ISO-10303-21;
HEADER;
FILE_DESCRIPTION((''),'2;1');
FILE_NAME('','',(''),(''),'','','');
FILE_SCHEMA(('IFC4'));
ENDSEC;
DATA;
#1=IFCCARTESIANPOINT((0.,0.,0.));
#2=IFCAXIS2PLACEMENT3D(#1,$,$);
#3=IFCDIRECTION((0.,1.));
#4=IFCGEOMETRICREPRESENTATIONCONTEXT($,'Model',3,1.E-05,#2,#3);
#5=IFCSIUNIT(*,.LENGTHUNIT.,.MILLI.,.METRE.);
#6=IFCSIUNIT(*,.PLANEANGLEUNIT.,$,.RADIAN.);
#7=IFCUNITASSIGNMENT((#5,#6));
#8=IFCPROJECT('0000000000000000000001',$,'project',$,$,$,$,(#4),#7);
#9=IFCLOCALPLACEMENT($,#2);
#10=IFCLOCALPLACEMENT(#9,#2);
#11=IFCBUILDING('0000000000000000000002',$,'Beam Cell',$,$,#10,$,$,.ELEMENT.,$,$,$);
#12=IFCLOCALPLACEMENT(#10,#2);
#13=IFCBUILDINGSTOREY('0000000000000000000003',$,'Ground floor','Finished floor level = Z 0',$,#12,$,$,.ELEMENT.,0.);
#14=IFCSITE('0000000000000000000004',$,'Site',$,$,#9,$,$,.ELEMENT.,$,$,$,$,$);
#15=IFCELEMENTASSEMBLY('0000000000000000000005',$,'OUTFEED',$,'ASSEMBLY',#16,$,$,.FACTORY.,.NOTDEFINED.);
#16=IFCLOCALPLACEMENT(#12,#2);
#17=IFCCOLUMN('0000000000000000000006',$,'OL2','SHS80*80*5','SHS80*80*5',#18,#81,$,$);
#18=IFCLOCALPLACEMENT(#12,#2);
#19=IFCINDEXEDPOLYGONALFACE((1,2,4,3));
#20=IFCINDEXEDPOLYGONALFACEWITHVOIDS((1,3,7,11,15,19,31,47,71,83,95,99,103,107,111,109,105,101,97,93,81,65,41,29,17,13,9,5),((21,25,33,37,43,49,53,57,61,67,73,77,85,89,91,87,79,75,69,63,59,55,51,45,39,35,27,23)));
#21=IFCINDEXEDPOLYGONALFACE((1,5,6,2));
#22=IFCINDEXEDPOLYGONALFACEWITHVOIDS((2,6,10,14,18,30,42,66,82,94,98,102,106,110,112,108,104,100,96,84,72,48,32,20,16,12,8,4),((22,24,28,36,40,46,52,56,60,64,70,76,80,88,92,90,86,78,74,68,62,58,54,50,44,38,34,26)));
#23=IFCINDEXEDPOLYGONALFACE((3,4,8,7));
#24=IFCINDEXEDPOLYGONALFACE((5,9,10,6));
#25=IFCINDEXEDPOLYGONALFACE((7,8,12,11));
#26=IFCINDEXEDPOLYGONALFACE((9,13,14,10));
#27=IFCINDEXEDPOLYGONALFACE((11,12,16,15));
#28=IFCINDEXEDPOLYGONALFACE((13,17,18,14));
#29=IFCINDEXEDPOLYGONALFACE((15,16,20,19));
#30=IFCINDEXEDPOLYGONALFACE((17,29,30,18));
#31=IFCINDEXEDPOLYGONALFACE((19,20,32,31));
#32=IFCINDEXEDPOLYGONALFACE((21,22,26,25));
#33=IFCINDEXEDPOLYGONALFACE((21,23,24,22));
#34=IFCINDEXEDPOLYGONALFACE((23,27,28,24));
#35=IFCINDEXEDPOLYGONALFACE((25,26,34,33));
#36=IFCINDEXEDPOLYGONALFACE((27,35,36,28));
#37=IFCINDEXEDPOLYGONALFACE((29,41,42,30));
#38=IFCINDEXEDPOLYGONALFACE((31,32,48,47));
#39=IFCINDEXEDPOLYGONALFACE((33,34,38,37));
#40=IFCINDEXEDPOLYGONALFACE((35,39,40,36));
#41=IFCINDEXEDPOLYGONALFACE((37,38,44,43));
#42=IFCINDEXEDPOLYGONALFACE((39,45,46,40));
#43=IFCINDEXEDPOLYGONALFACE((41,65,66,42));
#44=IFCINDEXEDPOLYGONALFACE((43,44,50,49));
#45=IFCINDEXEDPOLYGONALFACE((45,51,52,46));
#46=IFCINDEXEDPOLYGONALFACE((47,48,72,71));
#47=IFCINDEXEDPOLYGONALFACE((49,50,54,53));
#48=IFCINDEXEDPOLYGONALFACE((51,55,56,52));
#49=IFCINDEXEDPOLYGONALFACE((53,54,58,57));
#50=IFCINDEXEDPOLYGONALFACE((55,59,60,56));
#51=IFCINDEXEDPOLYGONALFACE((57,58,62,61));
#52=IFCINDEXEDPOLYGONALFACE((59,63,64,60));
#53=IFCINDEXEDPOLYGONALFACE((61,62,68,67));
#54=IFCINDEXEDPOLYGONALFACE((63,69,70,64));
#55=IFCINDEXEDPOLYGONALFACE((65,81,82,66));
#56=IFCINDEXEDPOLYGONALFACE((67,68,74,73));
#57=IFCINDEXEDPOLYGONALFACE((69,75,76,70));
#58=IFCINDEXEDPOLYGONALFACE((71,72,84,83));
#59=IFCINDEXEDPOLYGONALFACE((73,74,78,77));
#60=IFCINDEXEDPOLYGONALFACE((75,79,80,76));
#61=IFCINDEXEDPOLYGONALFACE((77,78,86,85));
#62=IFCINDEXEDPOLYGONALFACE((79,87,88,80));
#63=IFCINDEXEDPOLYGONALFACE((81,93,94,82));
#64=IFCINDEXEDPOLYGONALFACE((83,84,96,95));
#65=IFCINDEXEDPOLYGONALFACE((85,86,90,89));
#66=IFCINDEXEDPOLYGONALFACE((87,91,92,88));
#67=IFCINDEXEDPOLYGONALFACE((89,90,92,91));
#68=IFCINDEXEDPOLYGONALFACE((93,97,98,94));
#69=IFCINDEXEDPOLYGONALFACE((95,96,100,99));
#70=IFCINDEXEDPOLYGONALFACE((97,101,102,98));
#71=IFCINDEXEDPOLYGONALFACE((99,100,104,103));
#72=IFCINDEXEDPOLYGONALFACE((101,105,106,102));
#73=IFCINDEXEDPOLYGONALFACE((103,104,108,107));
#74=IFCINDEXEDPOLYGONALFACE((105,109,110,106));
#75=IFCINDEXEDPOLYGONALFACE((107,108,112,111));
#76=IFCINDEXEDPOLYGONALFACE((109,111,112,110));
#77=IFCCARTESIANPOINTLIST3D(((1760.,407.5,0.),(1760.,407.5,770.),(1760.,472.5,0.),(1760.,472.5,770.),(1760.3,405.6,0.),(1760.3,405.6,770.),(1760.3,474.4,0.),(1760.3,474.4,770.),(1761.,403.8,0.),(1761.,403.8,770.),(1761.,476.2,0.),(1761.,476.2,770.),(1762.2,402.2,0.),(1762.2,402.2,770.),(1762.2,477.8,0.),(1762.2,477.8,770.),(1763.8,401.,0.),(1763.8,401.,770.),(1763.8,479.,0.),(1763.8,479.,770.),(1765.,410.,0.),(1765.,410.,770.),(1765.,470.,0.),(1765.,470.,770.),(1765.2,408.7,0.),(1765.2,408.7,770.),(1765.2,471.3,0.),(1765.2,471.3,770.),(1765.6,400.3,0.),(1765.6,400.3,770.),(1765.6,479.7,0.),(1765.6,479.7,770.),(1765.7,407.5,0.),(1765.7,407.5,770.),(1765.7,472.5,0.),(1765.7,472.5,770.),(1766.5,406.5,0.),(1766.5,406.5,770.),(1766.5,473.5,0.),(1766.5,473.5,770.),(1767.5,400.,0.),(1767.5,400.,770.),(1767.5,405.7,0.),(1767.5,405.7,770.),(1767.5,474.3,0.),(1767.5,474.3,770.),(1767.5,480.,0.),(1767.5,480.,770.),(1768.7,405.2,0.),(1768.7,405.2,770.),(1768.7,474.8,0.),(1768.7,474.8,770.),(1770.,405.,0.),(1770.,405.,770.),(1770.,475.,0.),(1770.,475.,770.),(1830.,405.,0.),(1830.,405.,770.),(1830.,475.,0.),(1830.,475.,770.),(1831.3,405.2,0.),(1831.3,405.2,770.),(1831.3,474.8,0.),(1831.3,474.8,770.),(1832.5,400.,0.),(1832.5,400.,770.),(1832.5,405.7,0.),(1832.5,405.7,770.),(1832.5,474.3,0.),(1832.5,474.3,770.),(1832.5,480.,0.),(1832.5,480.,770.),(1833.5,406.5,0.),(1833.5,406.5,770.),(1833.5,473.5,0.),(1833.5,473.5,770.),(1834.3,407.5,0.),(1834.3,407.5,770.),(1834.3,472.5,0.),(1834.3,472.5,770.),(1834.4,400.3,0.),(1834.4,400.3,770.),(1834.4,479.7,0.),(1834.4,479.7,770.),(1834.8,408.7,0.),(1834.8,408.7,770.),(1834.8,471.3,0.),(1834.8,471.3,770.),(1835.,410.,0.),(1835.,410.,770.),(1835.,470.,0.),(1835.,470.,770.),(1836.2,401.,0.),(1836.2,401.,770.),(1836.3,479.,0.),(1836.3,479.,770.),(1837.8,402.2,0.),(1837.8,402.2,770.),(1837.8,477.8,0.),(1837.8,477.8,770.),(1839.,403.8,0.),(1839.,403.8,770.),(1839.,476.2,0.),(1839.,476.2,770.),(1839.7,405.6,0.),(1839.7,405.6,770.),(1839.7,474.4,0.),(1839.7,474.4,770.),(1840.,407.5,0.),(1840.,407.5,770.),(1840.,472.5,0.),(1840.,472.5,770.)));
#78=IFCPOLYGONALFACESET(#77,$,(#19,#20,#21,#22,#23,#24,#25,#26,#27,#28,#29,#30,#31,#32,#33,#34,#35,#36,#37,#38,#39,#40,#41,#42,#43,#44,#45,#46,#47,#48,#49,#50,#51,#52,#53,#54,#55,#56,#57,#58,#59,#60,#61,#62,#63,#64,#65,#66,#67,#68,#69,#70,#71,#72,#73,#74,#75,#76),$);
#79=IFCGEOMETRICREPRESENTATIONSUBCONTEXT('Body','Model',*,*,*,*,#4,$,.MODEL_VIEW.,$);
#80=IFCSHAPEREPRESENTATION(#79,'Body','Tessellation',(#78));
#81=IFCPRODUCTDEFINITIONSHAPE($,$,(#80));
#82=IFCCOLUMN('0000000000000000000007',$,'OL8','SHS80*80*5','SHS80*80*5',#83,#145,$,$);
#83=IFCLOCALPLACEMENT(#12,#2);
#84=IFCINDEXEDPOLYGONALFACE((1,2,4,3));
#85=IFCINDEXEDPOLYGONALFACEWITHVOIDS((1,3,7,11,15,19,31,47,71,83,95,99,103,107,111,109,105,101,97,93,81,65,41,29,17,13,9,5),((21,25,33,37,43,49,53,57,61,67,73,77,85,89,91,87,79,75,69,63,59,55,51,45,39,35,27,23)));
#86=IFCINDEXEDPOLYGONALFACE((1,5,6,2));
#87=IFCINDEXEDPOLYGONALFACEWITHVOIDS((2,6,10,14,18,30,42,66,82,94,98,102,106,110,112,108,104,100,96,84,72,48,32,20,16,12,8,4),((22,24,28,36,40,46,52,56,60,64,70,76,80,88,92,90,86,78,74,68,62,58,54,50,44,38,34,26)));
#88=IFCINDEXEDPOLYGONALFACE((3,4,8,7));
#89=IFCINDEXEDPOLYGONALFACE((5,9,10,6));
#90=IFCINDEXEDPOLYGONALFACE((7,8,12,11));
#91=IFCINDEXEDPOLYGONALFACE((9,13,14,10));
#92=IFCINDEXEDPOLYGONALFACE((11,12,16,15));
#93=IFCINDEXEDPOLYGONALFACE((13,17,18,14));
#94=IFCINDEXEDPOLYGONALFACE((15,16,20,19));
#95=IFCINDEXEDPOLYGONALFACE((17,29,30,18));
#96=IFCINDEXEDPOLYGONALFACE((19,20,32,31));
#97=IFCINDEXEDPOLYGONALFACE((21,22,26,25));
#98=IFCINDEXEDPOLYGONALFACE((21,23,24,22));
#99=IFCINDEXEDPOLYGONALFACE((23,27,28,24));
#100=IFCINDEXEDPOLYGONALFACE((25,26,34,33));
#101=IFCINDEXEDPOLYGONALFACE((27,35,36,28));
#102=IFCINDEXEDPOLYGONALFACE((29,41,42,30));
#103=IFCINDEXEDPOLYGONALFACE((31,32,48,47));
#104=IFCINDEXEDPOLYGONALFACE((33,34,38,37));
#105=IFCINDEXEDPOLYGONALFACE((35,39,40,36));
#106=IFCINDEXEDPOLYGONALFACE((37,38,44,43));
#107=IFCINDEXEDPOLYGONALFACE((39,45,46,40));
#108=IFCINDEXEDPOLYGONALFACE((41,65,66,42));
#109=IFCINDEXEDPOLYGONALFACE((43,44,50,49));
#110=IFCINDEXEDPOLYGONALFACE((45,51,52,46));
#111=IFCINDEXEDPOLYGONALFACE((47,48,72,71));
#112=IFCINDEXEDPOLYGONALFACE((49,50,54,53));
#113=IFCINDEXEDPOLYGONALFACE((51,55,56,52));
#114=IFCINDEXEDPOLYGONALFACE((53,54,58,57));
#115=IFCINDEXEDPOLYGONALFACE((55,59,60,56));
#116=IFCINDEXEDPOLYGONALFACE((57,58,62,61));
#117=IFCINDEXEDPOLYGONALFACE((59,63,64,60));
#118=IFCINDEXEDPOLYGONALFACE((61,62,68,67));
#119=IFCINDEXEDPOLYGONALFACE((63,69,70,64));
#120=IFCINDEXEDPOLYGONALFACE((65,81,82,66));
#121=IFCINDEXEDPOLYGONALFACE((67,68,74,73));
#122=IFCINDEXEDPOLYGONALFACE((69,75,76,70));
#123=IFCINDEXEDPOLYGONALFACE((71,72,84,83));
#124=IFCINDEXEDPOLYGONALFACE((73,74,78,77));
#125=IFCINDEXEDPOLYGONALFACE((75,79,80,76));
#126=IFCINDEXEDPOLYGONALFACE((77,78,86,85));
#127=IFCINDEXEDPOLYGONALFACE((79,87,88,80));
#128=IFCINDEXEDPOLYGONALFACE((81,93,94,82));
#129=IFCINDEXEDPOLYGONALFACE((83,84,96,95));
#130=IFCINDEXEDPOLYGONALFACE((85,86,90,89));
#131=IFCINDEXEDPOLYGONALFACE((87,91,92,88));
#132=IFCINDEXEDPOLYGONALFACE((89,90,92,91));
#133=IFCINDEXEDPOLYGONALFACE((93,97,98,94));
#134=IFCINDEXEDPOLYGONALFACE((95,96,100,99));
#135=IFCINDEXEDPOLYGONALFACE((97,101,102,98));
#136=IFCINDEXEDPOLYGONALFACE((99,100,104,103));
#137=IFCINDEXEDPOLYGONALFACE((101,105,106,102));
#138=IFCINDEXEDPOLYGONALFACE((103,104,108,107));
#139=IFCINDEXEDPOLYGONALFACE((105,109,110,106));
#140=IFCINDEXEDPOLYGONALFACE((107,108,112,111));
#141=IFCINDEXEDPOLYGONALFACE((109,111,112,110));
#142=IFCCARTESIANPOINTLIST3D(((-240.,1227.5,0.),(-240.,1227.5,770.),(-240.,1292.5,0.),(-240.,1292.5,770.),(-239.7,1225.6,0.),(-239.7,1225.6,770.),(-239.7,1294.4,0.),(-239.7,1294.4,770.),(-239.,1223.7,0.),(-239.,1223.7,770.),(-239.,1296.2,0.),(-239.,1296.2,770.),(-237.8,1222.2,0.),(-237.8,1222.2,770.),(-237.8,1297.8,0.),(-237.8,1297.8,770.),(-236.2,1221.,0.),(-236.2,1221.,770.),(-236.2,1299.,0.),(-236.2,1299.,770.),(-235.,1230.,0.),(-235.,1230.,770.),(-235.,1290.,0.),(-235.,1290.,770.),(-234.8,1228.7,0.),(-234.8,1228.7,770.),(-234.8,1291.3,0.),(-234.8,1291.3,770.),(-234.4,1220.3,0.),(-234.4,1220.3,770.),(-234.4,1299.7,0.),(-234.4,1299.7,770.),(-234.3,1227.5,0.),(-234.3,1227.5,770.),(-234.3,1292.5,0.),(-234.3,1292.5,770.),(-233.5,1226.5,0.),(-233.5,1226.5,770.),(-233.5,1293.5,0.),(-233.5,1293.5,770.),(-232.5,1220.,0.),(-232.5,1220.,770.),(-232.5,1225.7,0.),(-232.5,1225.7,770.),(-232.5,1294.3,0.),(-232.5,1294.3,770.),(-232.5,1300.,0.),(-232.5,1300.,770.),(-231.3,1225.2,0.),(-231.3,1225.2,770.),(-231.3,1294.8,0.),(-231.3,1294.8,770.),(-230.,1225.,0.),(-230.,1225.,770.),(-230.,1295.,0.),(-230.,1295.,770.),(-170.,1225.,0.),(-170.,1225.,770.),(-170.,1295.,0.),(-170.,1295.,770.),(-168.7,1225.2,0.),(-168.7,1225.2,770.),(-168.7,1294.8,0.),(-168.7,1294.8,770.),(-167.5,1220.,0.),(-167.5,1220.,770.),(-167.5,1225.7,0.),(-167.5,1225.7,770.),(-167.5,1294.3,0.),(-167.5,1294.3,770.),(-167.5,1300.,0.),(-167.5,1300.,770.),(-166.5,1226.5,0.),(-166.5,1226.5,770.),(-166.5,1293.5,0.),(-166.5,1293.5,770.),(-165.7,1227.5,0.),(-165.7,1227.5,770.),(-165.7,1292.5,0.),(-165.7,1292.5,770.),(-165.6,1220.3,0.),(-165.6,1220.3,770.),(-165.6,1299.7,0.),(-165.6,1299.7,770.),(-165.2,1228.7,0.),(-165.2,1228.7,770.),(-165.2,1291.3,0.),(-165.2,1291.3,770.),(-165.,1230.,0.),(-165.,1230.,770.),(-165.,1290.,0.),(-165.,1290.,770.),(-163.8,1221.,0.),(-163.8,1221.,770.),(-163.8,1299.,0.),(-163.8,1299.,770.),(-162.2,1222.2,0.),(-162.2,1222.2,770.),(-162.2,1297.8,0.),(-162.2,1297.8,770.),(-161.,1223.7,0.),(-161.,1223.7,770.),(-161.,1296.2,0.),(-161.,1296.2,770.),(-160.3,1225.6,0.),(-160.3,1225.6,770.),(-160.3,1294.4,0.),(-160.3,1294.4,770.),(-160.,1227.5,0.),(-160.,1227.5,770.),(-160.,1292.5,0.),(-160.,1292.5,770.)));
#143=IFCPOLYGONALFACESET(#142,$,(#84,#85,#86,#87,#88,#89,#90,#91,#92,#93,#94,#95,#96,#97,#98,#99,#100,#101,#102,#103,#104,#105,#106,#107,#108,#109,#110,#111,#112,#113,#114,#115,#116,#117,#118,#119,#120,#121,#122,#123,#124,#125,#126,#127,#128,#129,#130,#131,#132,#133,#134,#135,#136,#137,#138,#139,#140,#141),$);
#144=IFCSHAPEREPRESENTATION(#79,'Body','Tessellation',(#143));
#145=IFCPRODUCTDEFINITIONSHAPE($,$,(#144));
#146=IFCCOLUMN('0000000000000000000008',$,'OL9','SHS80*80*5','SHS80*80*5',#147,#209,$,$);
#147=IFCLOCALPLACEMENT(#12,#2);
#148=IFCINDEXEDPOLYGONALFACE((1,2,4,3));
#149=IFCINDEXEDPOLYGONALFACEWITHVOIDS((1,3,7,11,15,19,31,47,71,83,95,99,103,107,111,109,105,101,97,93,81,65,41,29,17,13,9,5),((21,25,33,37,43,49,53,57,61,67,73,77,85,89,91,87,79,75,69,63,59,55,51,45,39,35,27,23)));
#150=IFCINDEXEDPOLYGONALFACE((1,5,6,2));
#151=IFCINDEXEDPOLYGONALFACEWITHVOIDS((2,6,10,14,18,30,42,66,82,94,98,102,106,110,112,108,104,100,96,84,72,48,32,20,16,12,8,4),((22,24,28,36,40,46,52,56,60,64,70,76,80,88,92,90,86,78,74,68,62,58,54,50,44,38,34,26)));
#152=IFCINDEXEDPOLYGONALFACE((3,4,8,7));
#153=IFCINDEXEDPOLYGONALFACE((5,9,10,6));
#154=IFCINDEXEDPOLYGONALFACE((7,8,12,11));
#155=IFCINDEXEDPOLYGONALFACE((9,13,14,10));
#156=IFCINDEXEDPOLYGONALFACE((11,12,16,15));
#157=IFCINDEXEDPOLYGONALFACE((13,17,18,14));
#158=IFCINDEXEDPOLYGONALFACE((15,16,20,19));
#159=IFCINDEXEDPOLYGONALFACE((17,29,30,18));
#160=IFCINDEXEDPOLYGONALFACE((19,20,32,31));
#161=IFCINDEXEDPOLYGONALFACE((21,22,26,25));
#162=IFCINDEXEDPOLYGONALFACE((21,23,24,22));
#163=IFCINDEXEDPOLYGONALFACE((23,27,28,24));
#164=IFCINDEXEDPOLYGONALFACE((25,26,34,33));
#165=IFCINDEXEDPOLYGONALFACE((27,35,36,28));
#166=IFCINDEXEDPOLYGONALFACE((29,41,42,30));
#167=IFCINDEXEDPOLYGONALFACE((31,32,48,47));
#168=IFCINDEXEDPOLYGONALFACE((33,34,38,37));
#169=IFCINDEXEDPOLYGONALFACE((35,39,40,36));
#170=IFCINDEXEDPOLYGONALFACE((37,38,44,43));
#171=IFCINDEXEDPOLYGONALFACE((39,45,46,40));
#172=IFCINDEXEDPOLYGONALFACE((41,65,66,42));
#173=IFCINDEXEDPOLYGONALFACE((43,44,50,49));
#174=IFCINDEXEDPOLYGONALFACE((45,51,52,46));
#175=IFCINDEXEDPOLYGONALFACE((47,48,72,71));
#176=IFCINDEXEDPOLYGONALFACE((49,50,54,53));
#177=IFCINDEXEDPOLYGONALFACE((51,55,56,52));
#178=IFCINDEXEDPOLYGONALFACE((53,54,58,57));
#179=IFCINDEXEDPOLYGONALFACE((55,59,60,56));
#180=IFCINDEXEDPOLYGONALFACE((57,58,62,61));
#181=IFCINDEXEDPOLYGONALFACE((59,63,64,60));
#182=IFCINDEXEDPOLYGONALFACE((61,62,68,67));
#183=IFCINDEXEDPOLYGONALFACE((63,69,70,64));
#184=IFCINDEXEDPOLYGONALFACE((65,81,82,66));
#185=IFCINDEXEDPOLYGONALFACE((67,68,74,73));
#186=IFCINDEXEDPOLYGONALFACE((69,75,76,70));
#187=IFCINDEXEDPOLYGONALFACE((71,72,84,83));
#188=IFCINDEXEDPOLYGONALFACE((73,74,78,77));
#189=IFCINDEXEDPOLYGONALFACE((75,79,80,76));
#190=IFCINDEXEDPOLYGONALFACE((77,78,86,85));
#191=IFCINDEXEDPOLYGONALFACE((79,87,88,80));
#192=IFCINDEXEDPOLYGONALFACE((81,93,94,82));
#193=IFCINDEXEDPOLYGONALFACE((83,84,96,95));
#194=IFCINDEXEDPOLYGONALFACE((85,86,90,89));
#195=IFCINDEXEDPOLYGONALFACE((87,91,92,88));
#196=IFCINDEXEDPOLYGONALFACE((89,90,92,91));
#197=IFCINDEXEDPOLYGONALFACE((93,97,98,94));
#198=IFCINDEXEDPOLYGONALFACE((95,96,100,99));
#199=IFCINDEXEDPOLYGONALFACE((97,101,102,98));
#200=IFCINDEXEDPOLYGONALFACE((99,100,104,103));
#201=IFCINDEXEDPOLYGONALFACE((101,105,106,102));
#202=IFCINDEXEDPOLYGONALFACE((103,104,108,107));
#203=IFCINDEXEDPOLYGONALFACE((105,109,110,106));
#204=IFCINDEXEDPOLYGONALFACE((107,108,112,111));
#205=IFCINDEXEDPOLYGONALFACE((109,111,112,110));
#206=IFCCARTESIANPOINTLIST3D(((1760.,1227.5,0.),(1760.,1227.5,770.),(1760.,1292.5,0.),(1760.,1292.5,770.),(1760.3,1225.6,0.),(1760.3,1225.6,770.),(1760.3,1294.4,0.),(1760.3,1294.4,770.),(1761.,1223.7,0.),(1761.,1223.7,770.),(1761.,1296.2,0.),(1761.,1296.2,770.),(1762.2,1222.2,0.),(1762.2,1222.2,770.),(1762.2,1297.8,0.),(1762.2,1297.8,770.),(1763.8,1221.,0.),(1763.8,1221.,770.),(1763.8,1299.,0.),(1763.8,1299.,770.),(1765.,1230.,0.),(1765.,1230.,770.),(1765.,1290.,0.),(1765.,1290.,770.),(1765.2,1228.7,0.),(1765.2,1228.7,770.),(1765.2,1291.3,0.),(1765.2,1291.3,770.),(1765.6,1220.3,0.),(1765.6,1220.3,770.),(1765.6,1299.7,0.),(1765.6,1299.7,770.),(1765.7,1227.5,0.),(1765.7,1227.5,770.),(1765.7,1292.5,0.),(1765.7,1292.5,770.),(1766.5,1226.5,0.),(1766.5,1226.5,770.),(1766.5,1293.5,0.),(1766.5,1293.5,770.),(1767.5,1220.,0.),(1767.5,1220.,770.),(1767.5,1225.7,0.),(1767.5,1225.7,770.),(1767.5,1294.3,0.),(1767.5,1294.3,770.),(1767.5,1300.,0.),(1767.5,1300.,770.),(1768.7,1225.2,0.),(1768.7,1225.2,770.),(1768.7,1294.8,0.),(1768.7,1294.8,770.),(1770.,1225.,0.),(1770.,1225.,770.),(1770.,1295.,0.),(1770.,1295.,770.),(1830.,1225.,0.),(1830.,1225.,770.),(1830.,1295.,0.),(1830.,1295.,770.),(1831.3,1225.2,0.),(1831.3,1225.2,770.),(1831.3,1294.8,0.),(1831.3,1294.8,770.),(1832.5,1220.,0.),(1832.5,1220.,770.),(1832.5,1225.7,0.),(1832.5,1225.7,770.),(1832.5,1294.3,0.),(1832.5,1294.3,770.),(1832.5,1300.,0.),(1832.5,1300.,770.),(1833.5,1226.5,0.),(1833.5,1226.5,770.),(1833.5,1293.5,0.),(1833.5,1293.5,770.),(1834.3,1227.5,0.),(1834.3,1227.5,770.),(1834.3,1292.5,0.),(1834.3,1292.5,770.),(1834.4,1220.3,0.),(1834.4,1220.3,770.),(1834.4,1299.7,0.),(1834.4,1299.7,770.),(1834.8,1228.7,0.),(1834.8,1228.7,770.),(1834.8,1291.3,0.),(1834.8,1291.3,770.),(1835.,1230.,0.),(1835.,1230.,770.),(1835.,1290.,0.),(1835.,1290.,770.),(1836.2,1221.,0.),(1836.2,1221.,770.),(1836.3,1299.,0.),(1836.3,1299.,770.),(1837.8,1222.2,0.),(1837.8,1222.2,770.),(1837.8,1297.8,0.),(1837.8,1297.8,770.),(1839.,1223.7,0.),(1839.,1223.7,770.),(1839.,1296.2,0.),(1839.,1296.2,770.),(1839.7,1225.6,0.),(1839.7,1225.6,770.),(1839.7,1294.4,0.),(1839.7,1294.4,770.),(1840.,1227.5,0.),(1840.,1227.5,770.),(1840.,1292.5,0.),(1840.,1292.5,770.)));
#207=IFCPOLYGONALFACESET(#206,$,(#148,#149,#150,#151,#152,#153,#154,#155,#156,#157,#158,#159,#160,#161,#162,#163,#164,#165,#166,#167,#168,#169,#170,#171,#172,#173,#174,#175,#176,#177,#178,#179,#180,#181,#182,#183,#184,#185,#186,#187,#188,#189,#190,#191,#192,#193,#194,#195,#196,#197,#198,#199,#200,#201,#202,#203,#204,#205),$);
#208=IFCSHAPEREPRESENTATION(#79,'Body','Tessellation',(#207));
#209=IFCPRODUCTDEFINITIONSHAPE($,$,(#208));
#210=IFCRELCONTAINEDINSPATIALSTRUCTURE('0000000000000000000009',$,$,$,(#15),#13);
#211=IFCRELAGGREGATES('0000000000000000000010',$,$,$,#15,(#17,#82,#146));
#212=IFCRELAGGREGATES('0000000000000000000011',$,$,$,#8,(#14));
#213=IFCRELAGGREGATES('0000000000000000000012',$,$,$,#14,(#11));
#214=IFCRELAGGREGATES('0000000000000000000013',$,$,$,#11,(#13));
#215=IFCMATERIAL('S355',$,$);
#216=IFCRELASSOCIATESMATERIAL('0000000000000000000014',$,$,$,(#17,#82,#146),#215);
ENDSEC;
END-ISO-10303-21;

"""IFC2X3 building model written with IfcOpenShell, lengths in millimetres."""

from ifc_helpers import new_model, si_unit, direction, frame, origin, origin_2d, place, context, subcontext, project, spatial, hollow_rectangle, extrude, material, element, aggregate, save


model = new_model("IFC2X3")

# Units and contexts
model_context = context("Model", 3, precision=1e-05, world=origin(), true_north=direction((0.0, 1.0)))
body_context = subcontext(model_context, "Body", "Model", "MODEL_VIEW")
ifc_project = project(units=[si_unit("LENGTHUNIT", "METRE", prefix="MILLI"), si_unit("PLANEANGLEUNIT", "RADIAN")], contexts=[model_context])

# Site, building, storey
site_placement = place(None, origin())
site = spatial("IfcSite", under=ifc_project, at=site_placement, Name="Site", CompositionType="ELEMENT")
building_placement = place(site_placement, origin())
building = spatial("IfcBuilding", under=site, at=building_placement, Name="Beam Cell", CompositionType="ELEMENT")
storey_placement = place(building_placement, origin())
storey = spatial("IfcBuildingStorey", under=building, at=storey_placement, Name="Ground floor", Description="Finished floor level = Z 0", CompositionType="ELEMENT", Elevation=0.0)

# Shared definitions
ifc_material = material(Name="S355")

# Element assembly, columns
assembly_1_placement = place(storey_placement, origin())
assembly_1 = element("IfcElementAssembly", 1, at=assembly_1_placement, inside=storey, Name="OUTFEED", ObjectType="ASSEMBLY", AssemblyPlace="FACTORY", PredefinedType="NOTDEFINED")
column_1_placement = place(storey_placement, frame((1800.0, 440.0, 0.0), z_axis=(0.0, 0.0, 1.0), x_axis=(1.0, 0.0, 0.0)))
column_1 = element("IfcColumn", 2, at=column_1_placement, material=ifc_material, Name="OL2", Description="SHS80*80*5", ObjectType="SHS80*80*5", context=body_context, shape_type="SweptSolid", body=[
    extrude(hollow_rectangle(XDim=80.0, YDim=80.0, WallThickness=5.0, InnerFilletRadius=5.0, OuterFilletRadius=7.5, at=origin_2d()), origin(), (0.0, 0.0, 1.0), 770.0),
])
column_2_placement = place(storey_placement, frame((-200.0, 1260.0, 0.0), z_axis=(0.0, 0.0, 1.0), x_axis=(1.0, 0.0, 0.0)))
column_2 = element("IfcColumn", 3, at=column_2_placement, material=ifc_material, Name="OL8", Description="SHS80*80*5", ObjectType="SHS80*80*5", context=body_context, shape_type="SweptSolid", body=[
    extrude(hollow_rectangle(XDim=80.0, YDim=80.0, WallThickness=5.0, InnerFilletRadius=5.0, OuterFilletRadius=7.5, at=origin_2d()), origin(), (0.0, 0.0, 1.0), 770.0),
])
column_3_placement = place(storey_placement, frame((1800.0, 1260.0, 0.0), z_axis=(0.0, 0.0, 1.0), x_axis=(1.0, 0.0, 0.0)))
column_3 = element("IfcColumn", 4, at=column_3_placement, material=ifc_material, Name="OL9", Description="SHS80*80*5", ObjectType="SHS80*80*5", context=body_context, shape_type="SweptSolid", body=[
    extrude(hollow_rectangle(XDim=80.0, YDim=80.0, WallThickness=5.0, InnerFilletRadius=5.0, OuterFilletRadius=7.5, at=origin_2d()), origin(), (0.0, 0.0, 1.0), 770.0),
])

aggregate(assembly_1, [column_1, column_2, column_3])

save(model, "model.ifc")
